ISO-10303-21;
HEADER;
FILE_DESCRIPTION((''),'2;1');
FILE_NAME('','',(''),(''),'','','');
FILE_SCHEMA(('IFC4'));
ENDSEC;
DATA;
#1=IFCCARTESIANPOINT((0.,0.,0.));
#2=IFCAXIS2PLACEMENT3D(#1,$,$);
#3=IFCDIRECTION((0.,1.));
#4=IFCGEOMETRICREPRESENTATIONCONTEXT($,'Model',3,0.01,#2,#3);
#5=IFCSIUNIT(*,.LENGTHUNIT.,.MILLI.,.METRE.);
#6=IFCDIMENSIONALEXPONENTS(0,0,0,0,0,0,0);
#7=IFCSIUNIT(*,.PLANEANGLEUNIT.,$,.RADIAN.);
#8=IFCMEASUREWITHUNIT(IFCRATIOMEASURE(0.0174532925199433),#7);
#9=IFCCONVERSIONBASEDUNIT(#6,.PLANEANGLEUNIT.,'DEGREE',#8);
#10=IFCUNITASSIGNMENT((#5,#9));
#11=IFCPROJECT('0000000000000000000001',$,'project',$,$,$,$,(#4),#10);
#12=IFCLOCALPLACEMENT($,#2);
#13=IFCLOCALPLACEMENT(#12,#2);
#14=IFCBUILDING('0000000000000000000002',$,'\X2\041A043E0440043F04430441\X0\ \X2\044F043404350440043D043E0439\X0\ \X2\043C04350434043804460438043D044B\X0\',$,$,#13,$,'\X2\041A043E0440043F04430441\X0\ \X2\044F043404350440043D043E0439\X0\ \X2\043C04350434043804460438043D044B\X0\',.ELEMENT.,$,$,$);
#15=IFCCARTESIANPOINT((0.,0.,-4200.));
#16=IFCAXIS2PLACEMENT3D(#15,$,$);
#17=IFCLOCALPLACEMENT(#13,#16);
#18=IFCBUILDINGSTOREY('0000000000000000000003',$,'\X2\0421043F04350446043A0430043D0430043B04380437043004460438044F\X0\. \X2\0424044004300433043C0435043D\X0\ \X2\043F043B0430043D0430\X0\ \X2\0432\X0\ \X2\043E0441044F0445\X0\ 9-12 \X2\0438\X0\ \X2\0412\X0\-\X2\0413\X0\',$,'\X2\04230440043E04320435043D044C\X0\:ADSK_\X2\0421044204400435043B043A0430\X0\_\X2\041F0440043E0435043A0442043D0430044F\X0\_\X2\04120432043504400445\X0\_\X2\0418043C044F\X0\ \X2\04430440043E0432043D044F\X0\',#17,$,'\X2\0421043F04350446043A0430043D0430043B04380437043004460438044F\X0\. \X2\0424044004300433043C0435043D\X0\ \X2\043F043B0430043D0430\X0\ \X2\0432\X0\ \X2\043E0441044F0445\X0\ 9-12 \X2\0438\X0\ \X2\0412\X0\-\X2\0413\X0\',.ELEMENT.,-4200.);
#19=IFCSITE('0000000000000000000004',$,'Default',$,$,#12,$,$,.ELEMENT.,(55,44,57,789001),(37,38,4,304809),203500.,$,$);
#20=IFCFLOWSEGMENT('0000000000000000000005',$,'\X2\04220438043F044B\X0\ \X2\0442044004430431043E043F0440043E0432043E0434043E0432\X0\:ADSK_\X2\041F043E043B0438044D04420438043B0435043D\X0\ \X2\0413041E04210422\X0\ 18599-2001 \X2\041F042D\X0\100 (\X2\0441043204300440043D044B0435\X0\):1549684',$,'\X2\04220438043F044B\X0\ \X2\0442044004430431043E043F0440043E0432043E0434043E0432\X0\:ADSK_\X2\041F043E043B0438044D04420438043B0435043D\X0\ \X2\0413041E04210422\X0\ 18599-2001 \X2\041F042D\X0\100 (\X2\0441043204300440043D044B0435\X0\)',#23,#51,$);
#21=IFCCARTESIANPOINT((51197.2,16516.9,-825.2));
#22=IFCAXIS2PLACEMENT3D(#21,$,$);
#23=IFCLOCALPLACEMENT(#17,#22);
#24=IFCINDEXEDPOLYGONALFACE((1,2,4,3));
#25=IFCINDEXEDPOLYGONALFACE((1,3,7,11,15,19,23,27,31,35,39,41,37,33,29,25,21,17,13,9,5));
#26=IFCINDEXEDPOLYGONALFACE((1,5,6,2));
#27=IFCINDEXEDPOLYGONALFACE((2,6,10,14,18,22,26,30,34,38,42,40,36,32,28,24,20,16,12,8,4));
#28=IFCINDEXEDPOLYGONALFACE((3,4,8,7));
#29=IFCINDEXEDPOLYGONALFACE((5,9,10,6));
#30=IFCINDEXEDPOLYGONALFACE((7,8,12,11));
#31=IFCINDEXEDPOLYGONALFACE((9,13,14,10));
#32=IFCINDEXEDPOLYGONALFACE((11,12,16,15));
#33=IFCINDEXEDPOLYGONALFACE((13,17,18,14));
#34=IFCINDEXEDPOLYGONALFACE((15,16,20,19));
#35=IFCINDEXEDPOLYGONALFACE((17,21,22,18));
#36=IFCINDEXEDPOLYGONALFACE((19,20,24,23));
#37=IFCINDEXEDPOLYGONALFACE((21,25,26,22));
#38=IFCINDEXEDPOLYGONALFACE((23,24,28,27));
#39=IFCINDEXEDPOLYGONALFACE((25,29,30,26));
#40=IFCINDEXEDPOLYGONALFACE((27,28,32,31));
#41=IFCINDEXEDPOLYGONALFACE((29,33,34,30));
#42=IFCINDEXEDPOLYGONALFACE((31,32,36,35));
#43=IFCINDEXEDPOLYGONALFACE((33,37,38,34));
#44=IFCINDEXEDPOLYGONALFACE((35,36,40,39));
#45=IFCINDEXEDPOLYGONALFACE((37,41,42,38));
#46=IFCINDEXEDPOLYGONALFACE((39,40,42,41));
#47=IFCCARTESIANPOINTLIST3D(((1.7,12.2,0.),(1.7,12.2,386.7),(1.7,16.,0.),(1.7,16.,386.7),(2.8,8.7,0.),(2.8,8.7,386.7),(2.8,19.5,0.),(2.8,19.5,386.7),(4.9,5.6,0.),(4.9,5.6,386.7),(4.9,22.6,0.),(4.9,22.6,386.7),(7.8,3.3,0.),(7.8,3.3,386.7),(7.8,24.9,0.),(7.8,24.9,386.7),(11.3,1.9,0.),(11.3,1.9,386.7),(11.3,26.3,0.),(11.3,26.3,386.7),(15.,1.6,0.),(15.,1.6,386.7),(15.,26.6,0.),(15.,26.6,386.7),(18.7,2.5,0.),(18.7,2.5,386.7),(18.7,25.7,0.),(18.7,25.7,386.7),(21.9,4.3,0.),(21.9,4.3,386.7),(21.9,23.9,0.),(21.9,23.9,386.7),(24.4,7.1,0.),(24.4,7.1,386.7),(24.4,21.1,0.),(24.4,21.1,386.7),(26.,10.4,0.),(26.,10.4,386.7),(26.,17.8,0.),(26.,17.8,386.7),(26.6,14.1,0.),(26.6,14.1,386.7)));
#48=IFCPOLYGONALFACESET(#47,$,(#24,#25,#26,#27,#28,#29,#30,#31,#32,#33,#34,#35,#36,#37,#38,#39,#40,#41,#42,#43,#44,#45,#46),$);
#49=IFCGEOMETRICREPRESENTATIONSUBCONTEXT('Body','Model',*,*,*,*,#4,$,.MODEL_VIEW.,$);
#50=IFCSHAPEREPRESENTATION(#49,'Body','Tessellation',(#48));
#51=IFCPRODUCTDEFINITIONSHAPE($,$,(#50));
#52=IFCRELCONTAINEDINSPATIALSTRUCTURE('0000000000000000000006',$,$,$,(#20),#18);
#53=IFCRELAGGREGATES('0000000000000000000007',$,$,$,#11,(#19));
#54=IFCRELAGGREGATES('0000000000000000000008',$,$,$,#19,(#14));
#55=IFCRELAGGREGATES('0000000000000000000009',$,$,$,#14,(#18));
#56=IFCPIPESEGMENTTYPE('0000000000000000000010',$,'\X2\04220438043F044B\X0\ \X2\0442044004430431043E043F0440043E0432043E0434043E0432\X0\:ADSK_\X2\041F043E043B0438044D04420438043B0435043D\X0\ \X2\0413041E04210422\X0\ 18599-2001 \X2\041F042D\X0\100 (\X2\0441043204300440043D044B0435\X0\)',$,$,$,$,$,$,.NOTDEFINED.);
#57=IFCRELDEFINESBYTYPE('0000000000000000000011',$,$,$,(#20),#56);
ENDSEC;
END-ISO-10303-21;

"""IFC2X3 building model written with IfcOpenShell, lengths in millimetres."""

from ifc_helpers import new_model, entity, si_unit, converted_unit, direction, frame, origin, origin_2d_with_axis, place, context, subcontext, project, spatial, circle, extrude, type_object, element, save


model = new_model("IFC2X3")

# Units and contexts
model_context = context("Model", 3, precision=0.01, world=origin(), true_north=direction((0.0, 1.0)))
body_context = subcontext(model_context, "Body", "Model", "MODEL_VIEW")
ifc_project = project(units=[si_unit("LENGTHUNIT", "METRE", prefix="MILLI"), converted_unit("PLANEANGLEUNIT", "DEGREE", entity("IfcRatioMeasure", 0.0174532925199433), si_unit("PLANEANGLEUNIT", "RADIAN"), dimensions=[0, 0, 0, 0, 0, 0, 0])], contexts=[model_context])

# Site, building, storey
site_placement = place(None, frame((0.0, 0.0, 0.0)))
site = spatial("IfcSite", under=ifc_project, at=site_placement, Name="Default", CompositionType="ELEMENT", RefLatitude=(55, 44, 57, 789001), RefLongitude=(37, 38, 4, 304809), RefElevation=203500.0)
building_placement = place(site_placement, origin())
building = spatial("IfcBuilding", under=site, at=building_placement, Name="Корпус ядерной медицины", LongName="Корпус ядерной медицины", CompositionType="ELEMENT")
storey_placement = place(building_placement, frame((0.0, 0.0, -4200.0)))
storey = spatial("IfcBuildingStorey", under=building, at=storey_placement, Name="Спецканализация. Фрагмен плана в осях 9-12 и В-Г", ObjectType="Уровень:ADSK_Стрелка_Проектная_Вверх_Имя уровня", LongName="Спецканализация. Фрагмен плана в осях 9-12 и В-Г", CompositionType="ELEMENT", Elevation=-4200.0)

# Flow segment
pipe_segment_type = type_object("IfcPipeSegmentType", Name="Типы трубопроводов:ADSK_Полиэтилен ГОСТ 18599-2001 ПЭ100 (сварные)", PredefinedType="NOTDEFINED")
flow_segment_1_placement = place(storey_placement, frame((51197.2, 16516.9, -825.2)))
element("IfcFlowSegment", 1, at=flow_segment_1_placement, inside=storey, type_object=pipe_segment_type, Name="Типы трубопроводов:ADSK_Полиэтилен ГОСТ 18599-2001 ПЭ100 (сварные):1549684", ObjectType="Типы трубопроводов:ADSK_Полиэтилен ГОСТ 18599-2001 ПЭ100 (сварные)", context=body_context, shape_type="SweptSolid", body=[
    extrude(circle(Radius=12.5, at=origin_2d_with_axis()), frame((14.1, 14.1, 0.0)), (0.0, 0.0, 1.0), 386.7),
])

save(model, "model.ifc")
